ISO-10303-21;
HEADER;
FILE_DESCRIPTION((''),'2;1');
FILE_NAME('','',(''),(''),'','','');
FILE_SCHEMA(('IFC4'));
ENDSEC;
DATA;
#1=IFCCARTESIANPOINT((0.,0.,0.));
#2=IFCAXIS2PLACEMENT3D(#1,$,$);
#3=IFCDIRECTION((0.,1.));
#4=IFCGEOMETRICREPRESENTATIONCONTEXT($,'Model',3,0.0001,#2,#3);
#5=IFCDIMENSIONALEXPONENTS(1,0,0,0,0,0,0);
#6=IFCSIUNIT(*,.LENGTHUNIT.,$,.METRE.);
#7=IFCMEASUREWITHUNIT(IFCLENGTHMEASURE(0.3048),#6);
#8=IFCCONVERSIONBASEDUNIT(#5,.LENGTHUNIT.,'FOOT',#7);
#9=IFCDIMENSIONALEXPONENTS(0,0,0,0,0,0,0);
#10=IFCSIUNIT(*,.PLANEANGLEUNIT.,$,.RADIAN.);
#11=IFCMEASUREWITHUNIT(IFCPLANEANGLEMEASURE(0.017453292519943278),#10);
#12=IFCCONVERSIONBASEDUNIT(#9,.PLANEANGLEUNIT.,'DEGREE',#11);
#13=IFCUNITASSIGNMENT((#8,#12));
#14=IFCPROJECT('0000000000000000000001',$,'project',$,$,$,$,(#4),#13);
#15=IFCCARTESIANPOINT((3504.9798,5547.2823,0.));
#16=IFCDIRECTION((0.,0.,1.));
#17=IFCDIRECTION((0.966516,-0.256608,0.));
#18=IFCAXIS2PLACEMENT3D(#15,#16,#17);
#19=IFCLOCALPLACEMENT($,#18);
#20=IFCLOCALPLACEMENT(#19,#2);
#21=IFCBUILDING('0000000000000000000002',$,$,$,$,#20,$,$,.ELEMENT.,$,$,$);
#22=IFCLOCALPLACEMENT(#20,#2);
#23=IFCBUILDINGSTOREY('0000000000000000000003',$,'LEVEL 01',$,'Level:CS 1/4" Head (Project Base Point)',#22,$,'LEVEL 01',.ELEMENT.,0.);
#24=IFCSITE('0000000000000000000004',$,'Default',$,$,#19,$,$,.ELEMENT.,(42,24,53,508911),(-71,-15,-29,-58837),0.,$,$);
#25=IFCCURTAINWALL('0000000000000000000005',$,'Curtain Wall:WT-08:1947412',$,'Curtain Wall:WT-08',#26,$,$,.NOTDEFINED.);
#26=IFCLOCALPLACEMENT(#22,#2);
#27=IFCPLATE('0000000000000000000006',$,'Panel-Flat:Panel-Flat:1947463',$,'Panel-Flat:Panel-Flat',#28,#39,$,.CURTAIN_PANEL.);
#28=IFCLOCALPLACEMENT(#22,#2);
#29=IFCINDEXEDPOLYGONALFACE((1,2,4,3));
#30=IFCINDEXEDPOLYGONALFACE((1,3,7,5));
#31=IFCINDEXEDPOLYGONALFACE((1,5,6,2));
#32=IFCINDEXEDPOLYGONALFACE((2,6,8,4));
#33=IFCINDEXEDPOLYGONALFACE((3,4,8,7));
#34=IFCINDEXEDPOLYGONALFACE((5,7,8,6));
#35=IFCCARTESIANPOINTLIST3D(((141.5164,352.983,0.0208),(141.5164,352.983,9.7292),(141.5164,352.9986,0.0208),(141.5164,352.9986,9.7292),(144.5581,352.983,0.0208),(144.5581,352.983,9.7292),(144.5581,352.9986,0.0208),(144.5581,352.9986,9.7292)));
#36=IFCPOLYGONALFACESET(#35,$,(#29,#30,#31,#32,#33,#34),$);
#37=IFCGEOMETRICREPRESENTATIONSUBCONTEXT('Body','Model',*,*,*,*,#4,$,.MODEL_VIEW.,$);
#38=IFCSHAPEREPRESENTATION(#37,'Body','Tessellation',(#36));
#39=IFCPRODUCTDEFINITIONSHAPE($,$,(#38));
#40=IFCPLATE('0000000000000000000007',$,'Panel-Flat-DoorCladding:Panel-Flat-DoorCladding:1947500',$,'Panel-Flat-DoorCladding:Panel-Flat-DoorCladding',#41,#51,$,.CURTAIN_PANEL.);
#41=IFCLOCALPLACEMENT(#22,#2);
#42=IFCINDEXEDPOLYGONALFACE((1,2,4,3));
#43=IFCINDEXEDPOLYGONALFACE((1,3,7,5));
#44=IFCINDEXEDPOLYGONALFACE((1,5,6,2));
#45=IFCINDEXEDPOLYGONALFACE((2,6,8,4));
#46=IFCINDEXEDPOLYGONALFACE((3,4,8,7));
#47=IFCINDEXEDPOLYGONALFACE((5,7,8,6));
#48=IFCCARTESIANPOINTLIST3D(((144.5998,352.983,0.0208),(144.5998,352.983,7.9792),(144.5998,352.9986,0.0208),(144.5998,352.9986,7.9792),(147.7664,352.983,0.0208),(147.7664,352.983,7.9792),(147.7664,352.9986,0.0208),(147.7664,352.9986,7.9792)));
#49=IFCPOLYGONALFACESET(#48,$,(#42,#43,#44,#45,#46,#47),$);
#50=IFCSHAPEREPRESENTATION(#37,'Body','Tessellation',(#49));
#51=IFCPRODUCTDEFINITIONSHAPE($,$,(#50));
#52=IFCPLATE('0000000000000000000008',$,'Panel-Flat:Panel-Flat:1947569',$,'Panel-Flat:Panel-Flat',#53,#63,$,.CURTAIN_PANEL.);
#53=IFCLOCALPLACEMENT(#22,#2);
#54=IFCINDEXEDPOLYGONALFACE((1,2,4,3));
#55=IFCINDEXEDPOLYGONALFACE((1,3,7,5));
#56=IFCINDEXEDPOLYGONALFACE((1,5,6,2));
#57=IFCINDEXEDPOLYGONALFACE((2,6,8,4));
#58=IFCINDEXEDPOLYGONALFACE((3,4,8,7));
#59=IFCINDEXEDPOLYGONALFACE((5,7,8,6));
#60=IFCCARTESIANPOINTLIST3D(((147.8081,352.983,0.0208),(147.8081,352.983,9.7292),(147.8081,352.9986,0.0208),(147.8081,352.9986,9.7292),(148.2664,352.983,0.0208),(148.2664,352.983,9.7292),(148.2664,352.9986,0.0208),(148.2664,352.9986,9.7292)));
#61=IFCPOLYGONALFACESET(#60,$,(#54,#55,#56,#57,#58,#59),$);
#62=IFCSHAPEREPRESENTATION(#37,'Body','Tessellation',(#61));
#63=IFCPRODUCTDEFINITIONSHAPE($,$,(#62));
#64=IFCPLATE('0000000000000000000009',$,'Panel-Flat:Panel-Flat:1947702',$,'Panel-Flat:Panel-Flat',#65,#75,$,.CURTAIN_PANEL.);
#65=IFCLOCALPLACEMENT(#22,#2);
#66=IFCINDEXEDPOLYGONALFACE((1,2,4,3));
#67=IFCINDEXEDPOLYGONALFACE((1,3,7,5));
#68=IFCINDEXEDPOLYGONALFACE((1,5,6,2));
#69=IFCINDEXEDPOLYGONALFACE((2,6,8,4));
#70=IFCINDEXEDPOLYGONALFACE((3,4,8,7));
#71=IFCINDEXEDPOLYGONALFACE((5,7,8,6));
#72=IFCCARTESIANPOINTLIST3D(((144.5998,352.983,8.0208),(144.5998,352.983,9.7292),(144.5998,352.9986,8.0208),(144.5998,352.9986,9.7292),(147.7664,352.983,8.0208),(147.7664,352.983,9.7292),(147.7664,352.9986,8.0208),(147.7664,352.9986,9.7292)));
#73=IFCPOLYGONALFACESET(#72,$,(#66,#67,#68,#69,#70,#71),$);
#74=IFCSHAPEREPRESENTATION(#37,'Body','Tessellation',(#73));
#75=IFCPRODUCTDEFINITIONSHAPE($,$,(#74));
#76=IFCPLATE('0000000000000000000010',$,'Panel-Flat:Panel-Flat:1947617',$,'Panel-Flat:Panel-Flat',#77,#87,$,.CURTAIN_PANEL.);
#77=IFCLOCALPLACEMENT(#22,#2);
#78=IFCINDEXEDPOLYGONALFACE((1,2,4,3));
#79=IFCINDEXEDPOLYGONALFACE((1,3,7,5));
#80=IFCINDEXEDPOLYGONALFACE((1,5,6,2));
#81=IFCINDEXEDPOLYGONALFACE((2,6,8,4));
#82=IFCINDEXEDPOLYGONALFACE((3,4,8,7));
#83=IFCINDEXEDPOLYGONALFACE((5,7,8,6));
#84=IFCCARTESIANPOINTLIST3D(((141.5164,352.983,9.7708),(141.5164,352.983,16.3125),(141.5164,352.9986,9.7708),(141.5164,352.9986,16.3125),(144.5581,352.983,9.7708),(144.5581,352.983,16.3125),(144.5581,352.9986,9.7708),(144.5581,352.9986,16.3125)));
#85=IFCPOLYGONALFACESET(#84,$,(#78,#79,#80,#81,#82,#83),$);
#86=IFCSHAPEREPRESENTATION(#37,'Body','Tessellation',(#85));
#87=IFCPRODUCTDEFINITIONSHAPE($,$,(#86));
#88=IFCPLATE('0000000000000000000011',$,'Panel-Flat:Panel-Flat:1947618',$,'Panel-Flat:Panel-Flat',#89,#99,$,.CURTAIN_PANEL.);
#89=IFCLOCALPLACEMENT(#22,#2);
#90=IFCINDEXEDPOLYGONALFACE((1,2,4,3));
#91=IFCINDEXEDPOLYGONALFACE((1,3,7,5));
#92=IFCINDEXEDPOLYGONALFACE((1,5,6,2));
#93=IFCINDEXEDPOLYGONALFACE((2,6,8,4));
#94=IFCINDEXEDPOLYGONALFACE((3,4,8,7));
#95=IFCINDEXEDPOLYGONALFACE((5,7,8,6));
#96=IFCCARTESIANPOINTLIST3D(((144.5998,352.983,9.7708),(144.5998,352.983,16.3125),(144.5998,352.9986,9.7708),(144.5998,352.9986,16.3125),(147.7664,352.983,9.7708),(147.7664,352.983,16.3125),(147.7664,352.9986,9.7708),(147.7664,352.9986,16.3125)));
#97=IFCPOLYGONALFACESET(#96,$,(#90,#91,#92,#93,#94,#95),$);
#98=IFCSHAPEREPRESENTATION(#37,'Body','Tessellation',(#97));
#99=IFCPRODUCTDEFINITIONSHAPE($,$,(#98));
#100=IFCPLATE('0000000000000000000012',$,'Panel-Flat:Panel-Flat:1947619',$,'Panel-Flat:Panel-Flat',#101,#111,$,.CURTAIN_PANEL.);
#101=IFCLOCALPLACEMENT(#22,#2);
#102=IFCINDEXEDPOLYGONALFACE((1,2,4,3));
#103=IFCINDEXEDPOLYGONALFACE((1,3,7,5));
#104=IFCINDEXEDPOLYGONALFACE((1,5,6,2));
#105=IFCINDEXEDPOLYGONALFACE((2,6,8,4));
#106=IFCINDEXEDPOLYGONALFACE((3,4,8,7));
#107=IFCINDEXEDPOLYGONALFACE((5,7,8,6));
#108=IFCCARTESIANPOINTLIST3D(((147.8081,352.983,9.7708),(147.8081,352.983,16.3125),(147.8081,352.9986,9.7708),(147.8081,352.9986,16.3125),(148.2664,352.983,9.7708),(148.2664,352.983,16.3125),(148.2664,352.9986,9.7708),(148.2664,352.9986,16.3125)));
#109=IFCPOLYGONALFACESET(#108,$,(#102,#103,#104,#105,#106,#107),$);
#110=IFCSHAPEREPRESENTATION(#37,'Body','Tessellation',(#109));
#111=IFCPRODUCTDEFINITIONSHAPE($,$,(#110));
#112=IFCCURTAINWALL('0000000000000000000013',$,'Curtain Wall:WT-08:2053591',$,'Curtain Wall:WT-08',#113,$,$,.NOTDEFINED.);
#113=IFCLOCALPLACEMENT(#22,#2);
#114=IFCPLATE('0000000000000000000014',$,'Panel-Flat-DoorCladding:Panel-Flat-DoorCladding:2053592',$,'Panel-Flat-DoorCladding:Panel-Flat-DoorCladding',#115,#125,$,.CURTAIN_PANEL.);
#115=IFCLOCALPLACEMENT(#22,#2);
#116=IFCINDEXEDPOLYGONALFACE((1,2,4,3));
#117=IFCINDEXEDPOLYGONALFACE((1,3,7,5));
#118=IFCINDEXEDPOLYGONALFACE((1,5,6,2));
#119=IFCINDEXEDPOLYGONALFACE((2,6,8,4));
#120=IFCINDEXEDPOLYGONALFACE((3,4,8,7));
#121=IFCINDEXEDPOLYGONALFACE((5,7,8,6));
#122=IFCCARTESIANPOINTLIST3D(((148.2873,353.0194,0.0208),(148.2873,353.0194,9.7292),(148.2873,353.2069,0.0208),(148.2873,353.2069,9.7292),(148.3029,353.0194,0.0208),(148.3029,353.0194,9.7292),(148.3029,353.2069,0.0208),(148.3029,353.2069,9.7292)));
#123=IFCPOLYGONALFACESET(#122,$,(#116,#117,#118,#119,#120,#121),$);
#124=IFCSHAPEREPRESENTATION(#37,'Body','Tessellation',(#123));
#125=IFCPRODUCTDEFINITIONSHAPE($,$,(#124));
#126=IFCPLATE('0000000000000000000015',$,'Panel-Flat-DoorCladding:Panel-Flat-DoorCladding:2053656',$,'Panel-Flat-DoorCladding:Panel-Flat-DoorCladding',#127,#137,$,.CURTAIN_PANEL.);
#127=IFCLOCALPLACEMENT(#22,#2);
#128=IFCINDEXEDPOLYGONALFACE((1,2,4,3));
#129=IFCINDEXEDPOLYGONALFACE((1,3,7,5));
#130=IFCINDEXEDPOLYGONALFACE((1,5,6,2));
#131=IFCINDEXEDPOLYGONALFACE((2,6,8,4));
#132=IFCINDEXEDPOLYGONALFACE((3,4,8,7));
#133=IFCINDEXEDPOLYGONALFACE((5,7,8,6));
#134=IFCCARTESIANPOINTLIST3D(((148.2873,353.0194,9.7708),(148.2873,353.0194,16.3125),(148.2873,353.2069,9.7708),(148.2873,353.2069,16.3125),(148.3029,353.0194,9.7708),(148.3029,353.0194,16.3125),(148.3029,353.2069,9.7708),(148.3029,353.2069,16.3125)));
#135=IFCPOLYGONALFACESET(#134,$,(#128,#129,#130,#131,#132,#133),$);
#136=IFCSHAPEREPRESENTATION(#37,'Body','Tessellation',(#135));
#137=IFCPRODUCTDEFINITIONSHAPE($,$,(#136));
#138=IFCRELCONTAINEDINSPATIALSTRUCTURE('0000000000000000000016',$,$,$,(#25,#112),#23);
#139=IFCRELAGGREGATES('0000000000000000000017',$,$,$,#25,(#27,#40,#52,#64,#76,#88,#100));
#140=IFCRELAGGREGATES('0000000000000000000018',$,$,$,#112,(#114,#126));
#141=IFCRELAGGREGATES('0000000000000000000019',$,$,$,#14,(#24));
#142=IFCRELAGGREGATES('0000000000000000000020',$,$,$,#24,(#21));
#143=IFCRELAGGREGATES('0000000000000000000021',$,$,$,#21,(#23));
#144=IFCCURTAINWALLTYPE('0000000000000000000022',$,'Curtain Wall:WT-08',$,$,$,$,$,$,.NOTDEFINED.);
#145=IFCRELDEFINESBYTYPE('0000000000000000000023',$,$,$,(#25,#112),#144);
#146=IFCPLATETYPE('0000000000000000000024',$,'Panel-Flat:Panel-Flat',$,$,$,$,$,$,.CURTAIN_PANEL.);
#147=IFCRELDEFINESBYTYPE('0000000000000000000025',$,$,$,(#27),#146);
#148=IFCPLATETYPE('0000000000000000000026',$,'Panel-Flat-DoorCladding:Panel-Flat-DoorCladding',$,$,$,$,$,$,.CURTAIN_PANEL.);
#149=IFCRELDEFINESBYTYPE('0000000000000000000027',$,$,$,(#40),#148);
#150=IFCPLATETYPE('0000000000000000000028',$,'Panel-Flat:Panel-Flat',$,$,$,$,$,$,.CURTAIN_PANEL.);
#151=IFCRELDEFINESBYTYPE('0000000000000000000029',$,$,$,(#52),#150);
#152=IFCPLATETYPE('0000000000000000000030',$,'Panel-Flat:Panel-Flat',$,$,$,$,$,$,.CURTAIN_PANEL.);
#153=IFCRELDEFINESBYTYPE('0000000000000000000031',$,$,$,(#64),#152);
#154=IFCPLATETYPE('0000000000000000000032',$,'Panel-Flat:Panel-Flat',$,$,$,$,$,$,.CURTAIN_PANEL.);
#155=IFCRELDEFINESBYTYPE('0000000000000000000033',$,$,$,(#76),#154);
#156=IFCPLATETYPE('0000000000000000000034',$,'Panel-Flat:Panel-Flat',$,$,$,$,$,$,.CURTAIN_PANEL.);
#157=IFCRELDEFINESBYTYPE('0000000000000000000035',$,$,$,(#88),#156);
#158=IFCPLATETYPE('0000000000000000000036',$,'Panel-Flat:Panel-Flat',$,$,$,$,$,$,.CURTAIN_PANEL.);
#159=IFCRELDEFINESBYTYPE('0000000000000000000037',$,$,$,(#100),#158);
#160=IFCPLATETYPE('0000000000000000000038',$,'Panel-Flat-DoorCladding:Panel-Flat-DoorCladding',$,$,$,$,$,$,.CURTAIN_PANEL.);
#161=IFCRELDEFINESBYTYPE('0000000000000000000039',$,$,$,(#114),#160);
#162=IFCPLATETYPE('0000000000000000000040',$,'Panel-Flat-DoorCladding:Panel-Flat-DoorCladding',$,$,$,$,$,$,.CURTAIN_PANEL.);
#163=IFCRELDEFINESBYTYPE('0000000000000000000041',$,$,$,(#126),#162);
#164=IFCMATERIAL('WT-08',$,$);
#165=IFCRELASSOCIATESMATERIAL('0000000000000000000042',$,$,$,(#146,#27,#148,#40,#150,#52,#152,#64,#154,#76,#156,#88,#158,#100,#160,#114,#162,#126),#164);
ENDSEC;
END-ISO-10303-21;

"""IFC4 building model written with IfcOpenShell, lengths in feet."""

from ifc_helpers import new_model, entity, si_unit, converted_unit, direction, frame, origin, place, context, subcontext, project, spatial, indexed_curve, outline, extrude, source, transform, mapped, material, type_object, type_shapes, element, aggregate, save


model = new_model("IFC4")

# Units and contexts
model_context = context("Model", 3, precision=0.0001, world=origin(), true_north=direction((0.0, 1.0)))
body_context = subcontext(model_context, "Body", "Model", "MODEL_VIEW")
ifc_project = project(units=[converted_unit("LENGTHUNIT", "FOOT", entity("IfcLengthMeasure", 0.3048), si_unit("LENGTHUNIT", "METRE"), dimensions=[1, 0, 0, 0, 0, 0, 0]), converted_unit("PLANEANGLEUNIT", "DEGREE", entity("IfcPlaneAngleMeasure", 0.017453292519943278), si_unit("PLANEANGLEUNIT", "RADIAN"), dimensions=[0, 0, 0, 0, 0, 0, 0])], contexts=[model_context])

# Site, building, storey
site_placement = place(None, frame((3504.9798, 5547.2823, 0.0), z_axis=(0.0, 0.0, 1.0), x_axis=(0.966516, -0.256608, 0.0)))
site = spatial("IfcSite", under=ifc_project, at=site_placement, Name="Default", CompositionType="ELEMENT", RefLatitude=(42, 24, 53, 508911), RefLongitude=(-71, -15, -29, -58837), RefElevation=0.0)
building_placement = place(site_placement, origin())
building = spatial("IfcBuilding", under=site, at=building_placement, CompositionType="ELEMENT")
storey_placement = place(building_placement, origin())
storey = spatial("IfcBuildingStorey", under=building, at=storey_placement, Name="LEVEL 01", ObjectType="Level:CS 1/4\" Head (Project Base Point)", LongName="LEVEL 01", CompositionType="ELEMENT", Elevation=0.0)

# Curtain wall, plates
curtain_wall_type_1 = type_object("IfcCurtainWallType", Name="Curtain Wall:WT-08", PredefinedType="NOTDEFINED")
curtain_wall_1_placement = place(storey_placement, origin())
curtain_wall_1 = element("IfcCurtainWall", 1, at=curtain_wall_1_placement, inside=storey, type_object=curtain_wall_type_1, Name="Curtain Wall:WT-08:1947412", ObjectType="Curtain Wall:WT-08", PredefinedType="NOTDEFINED")
ifc_material_1 = material(Name="WT-08")
plate_type_1 = type_object("IfcPlateType", Name="Panel-Flat:Panel-Flat", PredefinedType="CURTAIN_PANEL", material=ifc_material_1)
shared_shape_1 = source(origin(), body_context, "Body", "SweptSolid", [
    extrude(outline(indexed_curve([(-0.0078, -1.5208), (0.0078, -1.5208), (0.0078, 1.5208), (-0.0078, 1.5208), (-0.0078, -1.5208)], self_intersect=False)), frame((0.0, -0.0078, 0.0208), z_axis=(0.0, 0.0, 1.0), x_axis=(0.0, -1.0, 0.0)), (0.0, 0.0, 1.0), 9.7083),
])
type_shapes(plate_type_1, [shared_shape_1])
plate_1_placement = place(curtain_wall_1_placement, frame((143.0373, 352.9986, 0.0)))
plate_1 = element("IfcPlate", 2, at=plate_1_placement, type_object=plate_type_1, material=ifc_material_1, Name="Panel-Flat:Panel-Flat:1947463", ObjectType="Panel-Flat:Panel-Flat", PredefinedType="CURTAIN_PANEL", context=body_context, shape_type="MappedRepresentation", body=[
    mapped(shared_shape_1, transform((0.0, 0.0, 0.0), scale=1.0)),
])
plate_type_2 = type_object("IfcPlateType", Name="Panel-Flat-DoorCladding:Panel-Flat-DoorCladding", PredefinedType="CURTAIN_PANEL", material=ifc_material_1)
shared_shape_2 = source(origin(), body_context, "Body", "SweptSolid", [
    extrude(outline(indexed_curve([(-0.0078, -1.5833), (0.0078, -1.5833), (0.0078, 1.5833), (-0.0078, 1.5833), (-0.0078, -1.5833)], self_intersect=False)), frame((0.0, -0.0078, 0.0208), z_axis=(0.0, 0.0, 1.0), x_axis=(0.0, -1.0, 0.0)), (0.0, 0.0, 1.0), 7.9583),
])
type_shapes(plate_type_2, [shared_shape_2])
plate_2_placement = place(curtain_wall_1_placement, frame((146.1831, 352.9986, 0.0)))
plate_2 = element("IfcPlate", 3, at=plate_2_placement, type_object=plate_type_2, material=ifc_material_1, Name="Panel-Flat-DoorCladding:Panel-Flat-DoorCladding:1947500", ObjectType="Panel-Flat-DoorCladding:Panel-Flat-DoorCladding", PredefinedType="CURTAIN_PANEL", context=body_context, shape_type="MappedRepresentation", body=[
    mapped(shared_shape_2, transform((0.0, 0.0, 0.0), scale=1.0)),
])
plate_type_3 = type_object("IfcPlateType", Name="Panel-Flat:Panel-Flat", PredefinedType="CURTAIN_PANEL", material=ifc_material_1)
shared_shape_3 = source(origin(), body_context, "Body", "SweptSolid", [
    extrude(outline(indexed_curve([(-0.0078, -0.2292), (0.0078, -0.2292), (0.0078, 0.2292), (-0.0078, 0.2292), (-0.0078, -0.2292)], self_intersect=False)), frame((0.0, -0.0078, 0.0208), z_axis=(0.0, 0.0, 1.0), x_axis=(0.0, -1.0, 0.0)), (0.0, 0.0, 1.0), 9.7083),
])
type_shapes(plate_type_3, [shared_shape_3])
plate_3_placement = place(curtain_wall_1_placement, frame((148.0373, 352.9986, 0.0)))
plate_3 = element("IfcPlate", 4, at=plate_3_placement, type_object=plate_type_3, material=ifc_material_1, Name="Panel-Flat:Panel-Flat:1947569", ObjectType="Panel-Flat:Panel-Flat", PredefinedType="CURTAIN_PANEL", context=body_context, shape_type="MappedRepresentation", body=[
    mapped(shared_shape_3, transform((0.0, 0.0, 0.0), scale=1.0)),
])
plate_type_4 = type_object("IfcPlateType", Name="Panel-Flat:Panel-Flat", PredefinedType="CURTAIN_PANEL", material=ifc_material_1)
shared_shape_4 = source(origin(), body_context, "Body", "SweptSolid", [
    extrude(outline(indexed_curve([(-0.0078, -1.5833), (0.0078, -1.5833), (0.0078, 1.5833), (-0.0078, 1.5833), (-0.0078, -1.5833)], self_intersect=False)), frame((0.0, -0.0078, 0.0208), z_axis=(0.0, 0.0, 1.0), x_axis=(0.0, -1.0, 0.0)), (0.0, 0.0, 1.0), 1.7083),
])
type_shapes(plate_type_4, [shared_shape_4])
plate_4_placement = place(curtain_wall_1_placement, frame((146.1831, 352.9986, 8.0)))
plate_4 = element("IfcPlate", 5, at=plate_4_placement, type_object=plate_type_4, material=ifc_material_1, Name="Panel-Flat:Panel-Flat:1947702", ObjectType="Panel-Flat:Panel-Flat", PredefinedType="CURTAIN_PANEL", context=body_context, shape_type="MappedRepresentation", body=[
    mapped(shared_shape_4, transform((0.0, 0.0, 0.0), scale=1.0)),
])
plate_type_5 = type_object("IfcPlateType", Name="Panel-Flat:Panel-Flat", PredefinedType="CURTAIN_PANEL", material=ifc_material_1)
shared_shape_5 = source(origin(), body_context, "Body", "SweptSolid", [
    extrude(outline(indexed_curve([(-0.0078, -1.5208), (0.0078, -1.5208), (0.0078, 1.5208), (-0.0078, 1.5208), (-0.0078, -1.5208)], self_intersect=False)), frame((0.0, -0.0078, 0.0208), z_axis=(0.0, 0.0, 1.0), x_axis=(0.0, -1.0, 0.0)), (0.0, 0.0, 1.0), 6.5417),
])
type_shapes(plate_type_5, [shared_shape_5])
plate_5_placement = place(curtain_wall_1_placement, frame((143.0373, 352.9986, 9.75)))
plate_5 = element("IfcPlate", 6, at=plate_5_placement, type_object=plate_type_5, material=ifc_material_1, Name="Panel-Flat:Panel-Flat:1947617", ObjectType="Panel-Flat:Panel-Flat", PredefinedType="CURTAIN_PANEL", context=body_context, shape_type="MappedRepresentation", body=[
    mapped(shared_shape_5, transform((0.0, 0.0, 0.0), scale=1.0)),
])
plate_type_6 = type_object("IfcPlateType", Name="Panel-Flat:Panel-Flat", PredefinedType="CURTAIN_PANEL", material=ifc_material_1)
shared_shape_6 = source(origin(), body_context, "Body", "SweptSolid", [
    extrude(outline(indexed_curve([(-0.0078, -1.5833), (0.0078, -1.5833), (0.0078, 1.5833), (-0.0078, 1.5833), (-0.0078, -1.5833)], self_intersect=False)), frame((0.0, -0.0078, 0.0208), z_axis=(0.0, 0.0, 1.0), x_axis=(0.0, -1.0, 0.0)), (0.0, 0.0, 1.0), 6.5417),
])
type_shapes(plate_type_6, [shared_shape_6])
plate_6_placement = place(curtain_wall_1_placement, frame((146.1831, 352.9986, 9.75)))
plate_6 = element("IfcPlate", 7, at=plate_6_placement, type_object=plate_type_6, material=ifc_material_1, Name="Panel-Flat:Panel-Flat:1947618", ObjectType="Panel-Flat:Panel-Flat", PredefinedType="CURTAIN_PANEL", context=body_context, shape_type="MappedRepresentation", body=[
    mapped(shared_shape_6, transform((0.0, 0.0, 0.0), scale=1.0)),
])
plate_type_7 = type_object("IfcPlateType", Name="Panel-Flat:Panel-Flat", PredefinedType="CURTAIN_PANEL", material=ifc_material_1)
shared_shape_7 = source(origin(), body_context, "Body", "SweptSolid", [
    extrude(outline(indexed_curve([(-0.0078, -0.2292), (0.0078, -0.2292), (0.0078, 0.2292), (-0.0078, 0.2292), (-0.0078, -0.2292)], self_intersect=False)), frame((0.0, -0.0078, 0.0208), z_axis=(0.0, 0.0, 1.0), x_axis=(0.0, -1.0, 0.0)), (0.0, 0.0, 1.0), 6.5417),
])
type_shapes(plate_type_7, [shared_shape_7])
plate_7_placement = place(curtain_wall_1_placement, frame((148.0373, 352.9986, 9.75)))
plate_7 = element("IfcPlate", 8, at=plate_7_placement, type_object=plate_type_7, material=ifc_material_1, Name="Panel-Flat:Panel-Flat:1947619", ObjectType="Panel-Flat:Panel-Flat", PredefinedType="CURTAIN_PANEL", context=body_context, shape_type="MappedRepresentation", body=[
    mapped(shared_shape_7, transform((0.0, 0.0, 0.0), scale=1.0)),
])
aggregate(curtain_wall_1, [plate_1, plate_2, plate_3, plate_4, plate_5, plate_6, plate_7])

# Curtain wall, plates
curtain_wall_2_placement = place(storey_placement, origin())
curtain_wall_2 = element("IfcCurtainWall", 9, at=curtain_wall_2_placement, inside=storey, type_object=curtain_wall_type_1, Name="Curtain Wall:WT-08:2053591", ObjectType="Curtain Wall:WT-08", PredefinedType="NOTDEFINED")
plate_type_8 = type_object("IfcPlateType", Name="Panel-Flat-DoorCladding:Panel-Flat-DoorCladding", PredefinedType="CURTAIN_PANEL", material=ifc_material_1)
shared_shape_8 = source(origin(), body_context, "Body", "SweptSolid", [
    extrude(outline(indexed_curve([(-0.0078, -0.0937), (0.0078, -0.0937), (0.0078, 0.0937), (-0.0078, 0.0937), (-0.0078, -0.0937)], self_intersect=False)), frame((0.0, -0.0078, 0.0208), z_axis=(0.0, 0.0, 1.0), x_axis=(0.0, -1.0, 0.0)), (0.0, 0.0, 1.0), 9.7083),
])
type_shapes(plate_type_8, [shared_shape_8])
plate_8_placement = place(curtain_wall_2_placement, frame((148.2873, 353.1132, 0.0), z_axis=(0.0, 0.0, 1.0), x_axis=(0.0, 1.0, 0.0)))
plate_8 = element("IfcPlate", 10, at=plate_8_placement, type_object=plate_type_8, material=ifc_material_1, Name="Panel-Flat-DoorCladding:Panel-Flat-DoorCladding:2053592", ObjectType="Panel-Flat-DoorCladding:Panel-Flat-DoorCladding", PredefinedType="CURTAIN_PANEL", context=body_context, shape_type="MappedRepresentation", body=[
    mapped(shared_shape_8, transform((0.0, 0.0, 0.0), scale=1.0)),
])
plate_type_9 = type_object("IfcPlateType", Name="Panel-Flat-DoorCladding:Panel-Flat-DoorCladding", PredefinedType="CURTAIN_PANEL", material=ifc_material_1)
shared_shape_9 = source(origin(), body_context, "Body", "SweptSolid", [
    extrude(outline(indexed_curve([(-0.0078, -0.0937), (0.0078, -0.0937), (0.0078, 0.0937), (-0.0078, 0.0937), (-0.0078, -0.0937)], self_intersect=False)), frame((0.0, -0.0078, 0.0208), z_axis=(0.0, 0.0, 1.0), x_axis=(0.0, -1.0, 0.0)), (0.0, 0.0, 1.0), 6.5417),
])
type_shapes(plate_type_9, [shared_shape_9])
plate_9_placement = place(curtain_wall_2_placement, frame((148.2873, 353.1132, 9.75), z_axis=(0.0, 0.0, 1.0), x_axis=(0.0, 1.0, 0.0)))
plate_9 = element("IfcPlate", 11, at=plate_9_placement, type_object=plate_type_9, material=ifc_material_1, Name="Panel-Flat-DoorCladding:Panel-Flat-DoorCladding:2053656", ObjectType="Panel-Flat-DoorCladding:Panel-Flat-DoorCladding", PredefinedType="CURTAIN_PANEL", context=body_context, shape_type="MappedRepresentation", body=[
    mapped(shared_shape_9, transform((0.0, 0.0, 0.0), scale=1.0)),
])
aggregate(curtain_wall_2, [plate_8, plate_9])

save(model, "model.ifc")
